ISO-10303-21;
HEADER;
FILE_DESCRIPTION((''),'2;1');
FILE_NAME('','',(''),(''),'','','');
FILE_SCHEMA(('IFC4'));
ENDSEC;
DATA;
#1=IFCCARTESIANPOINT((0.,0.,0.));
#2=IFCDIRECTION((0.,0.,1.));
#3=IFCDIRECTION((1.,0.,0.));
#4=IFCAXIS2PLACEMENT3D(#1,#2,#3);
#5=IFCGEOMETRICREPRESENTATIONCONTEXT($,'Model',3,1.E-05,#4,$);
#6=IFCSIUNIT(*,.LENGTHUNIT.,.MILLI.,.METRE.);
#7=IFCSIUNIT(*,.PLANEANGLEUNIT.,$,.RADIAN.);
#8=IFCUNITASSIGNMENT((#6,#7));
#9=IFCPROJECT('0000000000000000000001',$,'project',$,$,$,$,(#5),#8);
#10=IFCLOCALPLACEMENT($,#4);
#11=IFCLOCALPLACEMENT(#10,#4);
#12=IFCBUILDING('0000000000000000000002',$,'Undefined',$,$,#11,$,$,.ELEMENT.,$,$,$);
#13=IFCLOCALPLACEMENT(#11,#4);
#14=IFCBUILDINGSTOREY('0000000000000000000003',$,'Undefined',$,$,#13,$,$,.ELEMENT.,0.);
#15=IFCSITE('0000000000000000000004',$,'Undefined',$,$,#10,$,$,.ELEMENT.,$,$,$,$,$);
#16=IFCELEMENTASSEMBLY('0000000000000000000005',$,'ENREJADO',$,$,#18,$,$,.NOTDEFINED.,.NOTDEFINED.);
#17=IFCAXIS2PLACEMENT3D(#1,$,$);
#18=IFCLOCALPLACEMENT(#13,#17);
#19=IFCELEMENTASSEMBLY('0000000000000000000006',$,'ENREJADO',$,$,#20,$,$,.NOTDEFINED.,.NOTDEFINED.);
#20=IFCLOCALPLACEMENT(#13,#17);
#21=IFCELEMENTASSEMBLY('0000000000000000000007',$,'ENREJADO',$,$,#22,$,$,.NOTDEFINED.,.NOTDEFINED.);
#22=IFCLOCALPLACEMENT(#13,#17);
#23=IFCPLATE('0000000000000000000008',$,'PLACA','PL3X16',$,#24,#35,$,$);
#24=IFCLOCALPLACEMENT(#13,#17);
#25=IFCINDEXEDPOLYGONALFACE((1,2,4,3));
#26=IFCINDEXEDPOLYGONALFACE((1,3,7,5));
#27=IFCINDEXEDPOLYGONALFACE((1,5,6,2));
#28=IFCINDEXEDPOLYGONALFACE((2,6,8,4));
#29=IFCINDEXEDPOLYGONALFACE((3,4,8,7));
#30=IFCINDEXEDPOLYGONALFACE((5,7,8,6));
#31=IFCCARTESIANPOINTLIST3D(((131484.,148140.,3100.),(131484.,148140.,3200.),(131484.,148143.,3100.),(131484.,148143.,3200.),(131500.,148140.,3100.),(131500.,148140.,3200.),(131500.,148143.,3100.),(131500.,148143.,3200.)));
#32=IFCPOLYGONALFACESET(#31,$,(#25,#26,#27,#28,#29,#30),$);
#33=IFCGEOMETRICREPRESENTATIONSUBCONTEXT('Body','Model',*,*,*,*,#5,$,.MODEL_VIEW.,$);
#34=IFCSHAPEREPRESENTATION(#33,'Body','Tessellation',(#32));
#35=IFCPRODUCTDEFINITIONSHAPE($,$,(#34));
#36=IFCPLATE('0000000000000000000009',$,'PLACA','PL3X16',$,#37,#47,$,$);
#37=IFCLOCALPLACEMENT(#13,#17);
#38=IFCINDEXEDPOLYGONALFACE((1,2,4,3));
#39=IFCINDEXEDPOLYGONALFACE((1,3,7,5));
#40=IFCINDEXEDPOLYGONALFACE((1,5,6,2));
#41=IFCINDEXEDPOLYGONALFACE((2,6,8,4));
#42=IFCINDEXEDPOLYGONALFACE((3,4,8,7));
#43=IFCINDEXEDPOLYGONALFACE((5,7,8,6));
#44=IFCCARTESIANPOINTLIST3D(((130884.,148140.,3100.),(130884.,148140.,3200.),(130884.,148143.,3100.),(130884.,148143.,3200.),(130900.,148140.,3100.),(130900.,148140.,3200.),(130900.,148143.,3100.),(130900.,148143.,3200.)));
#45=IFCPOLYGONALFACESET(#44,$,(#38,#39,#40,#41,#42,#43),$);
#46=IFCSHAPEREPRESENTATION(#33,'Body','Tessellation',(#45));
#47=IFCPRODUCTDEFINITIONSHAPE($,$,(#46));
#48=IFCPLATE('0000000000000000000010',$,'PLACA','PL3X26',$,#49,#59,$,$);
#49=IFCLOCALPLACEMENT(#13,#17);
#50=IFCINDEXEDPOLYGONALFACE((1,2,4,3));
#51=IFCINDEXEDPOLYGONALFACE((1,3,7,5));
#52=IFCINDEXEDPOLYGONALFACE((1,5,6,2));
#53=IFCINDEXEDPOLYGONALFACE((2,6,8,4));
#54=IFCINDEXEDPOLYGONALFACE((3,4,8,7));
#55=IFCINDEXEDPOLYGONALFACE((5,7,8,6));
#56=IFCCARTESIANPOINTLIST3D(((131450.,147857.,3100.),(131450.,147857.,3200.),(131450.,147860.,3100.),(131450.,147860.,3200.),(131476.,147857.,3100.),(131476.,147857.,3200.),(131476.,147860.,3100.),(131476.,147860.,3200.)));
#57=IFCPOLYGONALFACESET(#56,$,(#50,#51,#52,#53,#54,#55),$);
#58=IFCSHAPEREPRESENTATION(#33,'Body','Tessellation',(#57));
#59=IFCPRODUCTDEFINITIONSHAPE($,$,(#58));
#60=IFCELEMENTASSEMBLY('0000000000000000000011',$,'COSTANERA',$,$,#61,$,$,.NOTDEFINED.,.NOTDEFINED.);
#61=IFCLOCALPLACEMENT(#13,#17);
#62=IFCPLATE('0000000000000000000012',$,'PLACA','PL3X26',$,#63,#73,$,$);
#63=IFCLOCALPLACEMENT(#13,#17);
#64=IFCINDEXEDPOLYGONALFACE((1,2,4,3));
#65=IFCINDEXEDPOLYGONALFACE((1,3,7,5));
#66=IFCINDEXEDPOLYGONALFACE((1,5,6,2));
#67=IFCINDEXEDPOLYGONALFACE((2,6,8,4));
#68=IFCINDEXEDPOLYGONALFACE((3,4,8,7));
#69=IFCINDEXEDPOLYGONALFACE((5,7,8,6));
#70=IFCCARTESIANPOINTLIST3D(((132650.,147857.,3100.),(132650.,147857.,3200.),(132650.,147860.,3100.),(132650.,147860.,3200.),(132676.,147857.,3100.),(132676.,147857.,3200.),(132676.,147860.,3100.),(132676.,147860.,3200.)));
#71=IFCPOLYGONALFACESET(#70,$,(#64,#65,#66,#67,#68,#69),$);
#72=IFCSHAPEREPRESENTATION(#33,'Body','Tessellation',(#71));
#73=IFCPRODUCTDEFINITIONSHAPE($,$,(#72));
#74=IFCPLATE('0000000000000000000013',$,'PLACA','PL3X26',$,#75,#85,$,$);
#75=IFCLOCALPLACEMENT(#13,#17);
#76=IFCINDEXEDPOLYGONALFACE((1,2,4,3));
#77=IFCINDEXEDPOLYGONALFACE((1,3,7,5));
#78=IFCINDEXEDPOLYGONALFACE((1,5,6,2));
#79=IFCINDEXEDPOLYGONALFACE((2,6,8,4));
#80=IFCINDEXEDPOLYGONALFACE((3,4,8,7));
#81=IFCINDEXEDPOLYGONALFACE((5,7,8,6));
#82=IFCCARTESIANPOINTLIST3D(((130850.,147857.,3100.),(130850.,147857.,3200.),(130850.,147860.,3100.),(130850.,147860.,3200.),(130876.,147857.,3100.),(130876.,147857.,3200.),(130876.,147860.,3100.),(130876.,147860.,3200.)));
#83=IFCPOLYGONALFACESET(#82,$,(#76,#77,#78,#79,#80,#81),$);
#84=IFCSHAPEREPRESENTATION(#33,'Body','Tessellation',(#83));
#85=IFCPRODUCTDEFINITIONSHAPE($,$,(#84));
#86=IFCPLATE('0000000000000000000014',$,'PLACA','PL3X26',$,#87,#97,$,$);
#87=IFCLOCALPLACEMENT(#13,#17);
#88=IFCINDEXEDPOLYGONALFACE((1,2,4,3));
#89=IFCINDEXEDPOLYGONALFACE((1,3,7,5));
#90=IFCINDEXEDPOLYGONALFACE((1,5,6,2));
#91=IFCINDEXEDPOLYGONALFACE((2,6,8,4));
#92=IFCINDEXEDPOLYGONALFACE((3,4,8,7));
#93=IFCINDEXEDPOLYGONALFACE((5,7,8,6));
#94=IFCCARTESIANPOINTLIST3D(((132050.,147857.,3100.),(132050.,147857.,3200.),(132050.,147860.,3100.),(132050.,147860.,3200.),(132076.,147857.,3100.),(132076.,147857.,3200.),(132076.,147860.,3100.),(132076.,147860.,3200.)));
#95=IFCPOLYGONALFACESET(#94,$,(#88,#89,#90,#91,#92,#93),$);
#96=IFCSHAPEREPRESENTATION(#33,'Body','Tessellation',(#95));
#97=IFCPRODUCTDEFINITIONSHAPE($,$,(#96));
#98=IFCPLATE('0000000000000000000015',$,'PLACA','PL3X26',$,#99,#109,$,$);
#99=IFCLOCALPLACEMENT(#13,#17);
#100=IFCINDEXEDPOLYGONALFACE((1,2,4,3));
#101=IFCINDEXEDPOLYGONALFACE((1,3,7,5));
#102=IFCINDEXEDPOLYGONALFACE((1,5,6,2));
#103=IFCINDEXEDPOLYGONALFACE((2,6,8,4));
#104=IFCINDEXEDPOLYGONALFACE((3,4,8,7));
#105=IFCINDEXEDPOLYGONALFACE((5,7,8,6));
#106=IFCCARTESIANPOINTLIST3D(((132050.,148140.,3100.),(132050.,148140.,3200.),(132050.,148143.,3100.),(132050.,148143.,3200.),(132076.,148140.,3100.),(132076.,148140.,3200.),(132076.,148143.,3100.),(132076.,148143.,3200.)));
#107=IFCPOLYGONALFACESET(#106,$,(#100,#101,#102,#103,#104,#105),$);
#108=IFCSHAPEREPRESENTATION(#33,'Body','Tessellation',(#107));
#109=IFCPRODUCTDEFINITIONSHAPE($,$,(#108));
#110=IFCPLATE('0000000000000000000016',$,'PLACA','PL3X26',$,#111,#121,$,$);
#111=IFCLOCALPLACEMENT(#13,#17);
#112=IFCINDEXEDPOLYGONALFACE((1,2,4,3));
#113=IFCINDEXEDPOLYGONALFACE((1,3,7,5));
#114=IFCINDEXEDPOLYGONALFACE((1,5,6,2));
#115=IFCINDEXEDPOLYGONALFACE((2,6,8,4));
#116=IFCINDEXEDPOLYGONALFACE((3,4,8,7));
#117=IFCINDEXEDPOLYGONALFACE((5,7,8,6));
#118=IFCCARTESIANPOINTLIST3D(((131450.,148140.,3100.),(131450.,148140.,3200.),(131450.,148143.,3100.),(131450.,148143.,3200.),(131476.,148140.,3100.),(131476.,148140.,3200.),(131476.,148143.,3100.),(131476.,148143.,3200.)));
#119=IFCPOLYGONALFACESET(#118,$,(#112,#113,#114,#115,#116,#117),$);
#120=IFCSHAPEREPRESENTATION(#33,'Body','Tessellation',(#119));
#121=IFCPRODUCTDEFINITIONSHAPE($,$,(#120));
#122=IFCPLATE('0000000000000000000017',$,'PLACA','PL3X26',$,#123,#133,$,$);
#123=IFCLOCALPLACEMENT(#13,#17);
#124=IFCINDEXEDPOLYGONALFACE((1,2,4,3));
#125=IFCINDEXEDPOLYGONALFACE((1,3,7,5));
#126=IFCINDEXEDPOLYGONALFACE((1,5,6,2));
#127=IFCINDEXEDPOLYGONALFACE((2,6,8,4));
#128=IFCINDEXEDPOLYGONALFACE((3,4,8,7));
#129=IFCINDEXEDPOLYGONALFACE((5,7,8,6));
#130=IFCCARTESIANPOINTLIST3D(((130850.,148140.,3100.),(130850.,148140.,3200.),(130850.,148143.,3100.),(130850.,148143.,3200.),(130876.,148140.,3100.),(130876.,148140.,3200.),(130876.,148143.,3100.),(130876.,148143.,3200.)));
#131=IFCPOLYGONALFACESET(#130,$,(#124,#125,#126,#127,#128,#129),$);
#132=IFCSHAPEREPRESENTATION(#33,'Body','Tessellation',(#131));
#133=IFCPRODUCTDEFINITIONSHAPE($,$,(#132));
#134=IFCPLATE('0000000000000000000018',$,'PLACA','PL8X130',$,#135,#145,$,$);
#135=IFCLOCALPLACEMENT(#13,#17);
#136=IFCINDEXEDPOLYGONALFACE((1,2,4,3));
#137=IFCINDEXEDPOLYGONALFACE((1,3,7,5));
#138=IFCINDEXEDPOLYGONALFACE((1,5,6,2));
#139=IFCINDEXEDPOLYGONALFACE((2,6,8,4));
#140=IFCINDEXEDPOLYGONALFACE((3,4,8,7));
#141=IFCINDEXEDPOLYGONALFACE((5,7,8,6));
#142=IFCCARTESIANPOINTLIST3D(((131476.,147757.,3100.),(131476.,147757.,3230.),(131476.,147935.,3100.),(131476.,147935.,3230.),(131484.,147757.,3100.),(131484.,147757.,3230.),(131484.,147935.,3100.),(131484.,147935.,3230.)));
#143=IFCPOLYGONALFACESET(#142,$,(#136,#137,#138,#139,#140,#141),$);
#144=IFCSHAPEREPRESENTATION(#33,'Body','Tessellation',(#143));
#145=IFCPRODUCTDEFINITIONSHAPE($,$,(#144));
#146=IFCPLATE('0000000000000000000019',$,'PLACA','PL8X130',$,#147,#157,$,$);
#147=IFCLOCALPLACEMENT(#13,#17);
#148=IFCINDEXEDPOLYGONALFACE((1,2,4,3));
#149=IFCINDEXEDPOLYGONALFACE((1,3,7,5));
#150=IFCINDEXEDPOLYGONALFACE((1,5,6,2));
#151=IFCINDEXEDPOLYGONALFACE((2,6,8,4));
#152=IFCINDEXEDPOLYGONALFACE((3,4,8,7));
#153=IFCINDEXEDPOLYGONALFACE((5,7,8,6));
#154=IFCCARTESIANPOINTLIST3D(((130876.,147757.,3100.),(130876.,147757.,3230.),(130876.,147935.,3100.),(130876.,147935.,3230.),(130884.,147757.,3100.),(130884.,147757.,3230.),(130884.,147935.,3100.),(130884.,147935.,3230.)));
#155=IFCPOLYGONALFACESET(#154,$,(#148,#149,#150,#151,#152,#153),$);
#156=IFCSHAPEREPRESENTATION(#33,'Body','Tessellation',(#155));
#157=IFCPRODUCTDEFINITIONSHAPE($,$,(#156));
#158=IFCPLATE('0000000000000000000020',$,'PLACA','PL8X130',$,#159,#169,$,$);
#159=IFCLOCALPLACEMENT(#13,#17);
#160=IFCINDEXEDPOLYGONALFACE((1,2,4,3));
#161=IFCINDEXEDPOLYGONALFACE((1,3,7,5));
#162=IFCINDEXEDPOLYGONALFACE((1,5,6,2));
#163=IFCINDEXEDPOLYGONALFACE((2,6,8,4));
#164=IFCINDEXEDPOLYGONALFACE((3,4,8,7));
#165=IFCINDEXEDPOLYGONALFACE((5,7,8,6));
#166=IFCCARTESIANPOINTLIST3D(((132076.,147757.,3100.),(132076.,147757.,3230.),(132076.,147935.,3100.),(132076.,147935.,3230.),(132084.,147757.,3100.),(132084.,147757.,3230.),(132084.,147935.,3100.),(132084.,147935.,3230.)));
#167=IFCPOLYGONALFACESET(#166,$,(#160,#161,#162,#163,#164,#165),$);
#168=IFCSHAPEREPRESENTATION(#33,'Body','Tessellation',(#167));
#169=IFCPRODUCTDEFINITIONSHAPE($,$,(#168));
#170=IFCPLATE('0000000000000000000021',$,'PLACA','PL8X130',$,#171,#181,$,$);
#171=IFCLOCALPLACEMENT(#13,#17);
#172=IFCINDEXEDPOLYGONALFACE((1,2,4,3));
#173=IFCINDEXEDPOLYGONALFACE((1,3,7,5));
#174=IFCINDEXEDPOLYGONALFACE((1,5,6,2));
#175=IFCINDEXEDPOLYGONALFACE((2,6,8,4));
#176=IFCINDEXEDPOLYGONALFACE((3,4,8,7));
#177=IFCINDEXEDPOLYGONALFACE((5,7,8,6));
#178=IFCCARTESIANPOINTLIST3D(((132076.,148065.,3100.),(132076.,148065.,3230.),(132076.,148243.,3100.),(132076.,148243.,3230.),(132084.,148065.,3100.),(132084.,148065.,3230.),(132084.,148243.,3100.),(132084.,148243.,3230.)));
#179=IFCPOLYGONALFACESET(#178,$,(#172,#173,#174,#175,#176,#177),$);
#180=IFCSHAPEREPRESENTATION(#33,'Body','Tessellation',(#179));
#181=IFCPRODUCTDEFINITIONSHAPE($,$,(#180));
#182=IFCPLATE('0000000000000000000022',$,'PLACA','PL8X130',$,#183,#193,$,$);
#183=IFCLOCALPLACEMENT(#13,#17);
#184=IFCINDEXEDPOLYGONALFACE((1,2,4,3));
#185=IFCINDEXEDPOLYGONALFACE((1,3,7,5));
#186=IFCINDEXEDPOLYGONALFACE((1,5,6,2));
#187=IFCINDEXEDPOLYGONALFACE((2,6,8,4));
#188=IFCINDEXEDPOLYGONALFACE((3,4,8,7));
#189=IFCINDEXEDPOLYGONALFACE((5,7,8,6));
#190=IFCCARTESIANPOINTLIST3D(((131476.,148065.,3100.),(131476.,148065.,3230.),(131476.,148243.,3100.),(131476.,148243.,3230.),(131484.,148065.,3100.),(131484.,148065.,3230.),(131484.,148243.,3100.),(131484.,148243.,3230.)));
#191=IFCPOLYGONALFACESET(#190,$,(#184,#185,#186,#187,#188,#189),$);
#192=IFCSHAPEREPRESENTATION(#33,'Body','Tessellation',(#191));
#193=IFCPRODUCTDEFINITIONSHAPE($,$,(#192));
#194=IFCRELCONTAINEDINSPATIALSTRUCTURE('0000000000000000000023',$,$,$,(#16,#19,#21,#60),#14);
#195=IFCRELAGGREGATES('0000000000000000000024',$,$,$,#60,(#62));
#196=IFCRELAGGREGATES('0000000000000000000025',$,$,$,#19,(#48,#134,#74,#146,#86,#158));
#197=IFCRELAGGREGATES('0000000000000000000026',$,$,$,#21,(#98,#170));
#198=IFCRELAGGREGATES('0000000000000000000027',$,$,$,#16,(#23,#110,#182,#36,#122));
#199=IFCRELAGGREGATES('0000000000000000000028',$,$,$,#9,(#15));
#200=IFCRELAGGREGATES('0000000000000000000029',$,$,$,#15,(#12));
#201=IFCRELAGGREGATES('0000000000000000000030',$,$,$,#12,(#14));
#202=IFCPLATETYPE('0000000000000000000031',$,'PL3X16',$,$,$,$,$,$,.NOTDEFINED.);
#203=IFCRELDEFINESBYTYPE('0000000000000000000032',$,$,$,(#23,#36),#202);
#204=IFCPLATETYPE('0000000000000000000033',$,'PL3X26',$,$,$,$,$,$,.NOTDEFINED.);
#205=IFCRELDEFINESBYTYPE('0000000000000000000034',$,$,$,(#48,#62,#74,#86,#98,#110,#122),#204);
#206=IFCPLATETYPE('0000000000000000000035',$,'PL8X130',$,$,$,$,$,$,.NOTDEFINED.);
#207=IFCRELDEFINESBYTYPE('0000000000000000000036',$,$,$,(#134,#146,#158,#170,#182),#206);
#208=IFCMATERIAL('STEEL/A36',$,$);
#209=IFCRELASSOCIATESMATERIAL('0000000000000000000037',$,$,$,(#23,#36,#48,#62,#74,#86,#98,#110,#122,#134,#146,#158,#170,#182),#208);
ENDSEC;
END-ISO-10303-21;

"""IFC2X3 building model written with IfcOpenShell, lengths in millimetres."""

from ifc_helpers import new_model, si_unit, frame, origin_with_axes, place, context, subcontext, project, spatial, polyline, outline, extrude, material, type_object, element, aggregate, save


model = new_model("IFC2X3")

# Units and contexts
model_context = context("Model", 3, precision=1e-05, world=origin_with_axes())
body_context = subcontext(model_context, "Body", "Model", "MODEL_VIEW")
ifc_project = project(units=[si_unit("LENGTHUNIT", "METRE", prefix="MILLI"), si_unit("PLANEANGLEUNIT", "RADIAN")], contexts=[model_context])

# Site, building, storey
site_placement = place(None, origin_with_axes())
site = spatial("IfcSite", under=ifc_project, at=site_placement, Name="Undefined", CompositionType="ELEMENT")
building_placement = place(site_placement, origin_with_axes())
building = spatial("IfcBuilding", under=site, at=building_placement, Name="Undefined", CompositionType="ELEMENT")
storey_placement = place(building_placement, origin_with_axes())
storey = spatial("IfcBuildingStorey", under=building, at=storey_placement, Name="Undefined", CompositionType="ELEMENT", Elevation=0.0)

# Shared definitions
ifc_material_1 = material(Name="STEEL/A36")

# Element assembly
assembly_1_placement = place(storey_placement, origin_with_axes())
assembly_1 = element("IfcElementAssembly", 1, at=assembly_1_placement, inside=storey, Name="ENREJADO", AssemblyPlace="NOTDEFINED", PredefinedType="NOTDEFINED")

# Element assembly
assembly_2_placement = place(storey_placement, origin_with_axes())
assembly_2 = element("IfcElementAssembly", 2, at=assembly_2_placement, inside=storey, Name="ENREJADO", AssemblyPlace="NOTDEFINED", PredefinedType="NOTDEFINED")

# Element assembly
assembly_3_placement = place(storey_placement, origin_with_axes())
assembly_3 = element("IfcElementAssembly", 3, at=assembly_3_placement, inside=storey, Name="ENREJADO", AssemblyPlace="NOTDEFINED", PredefinedType="NOTDEFINED")

# Plates
plate_type_1 = type_object("IfcPlateType", Name="PL3X16", PredefinedType="NOTDEFINED")
plate_1_placement = place(assembly_1_placement, frame((131500.0, 148141.5, 3100.0), z_axis=(0.000001, 1.0, 0.0), x_axis=(-1.0, 0.000001, 0.0)))
plate_1 = element("IfcPlate", 4, at=plate_1_placement, type_object=plate_type_1, material=ifc_material_1, Name="PLACA", Description="PL3X16", context=body_context, shape_type="SweptSolid", body=[
    extrude(outline(polyline([(0.0, 0.0), (16.0, 0.0), (16.0, 100.0), (0.0, 100.0), (0.0, 0.0)])), frame((0.0, 0.0, -1.5), z_axis=(0.0, 0.0, 1.0), x_axis=(1.0, 0.0, 0.0)), (0.0, 0.0, 1.0), 3.0),
])
plate_2_placement = place(assembly_1_placement, frame((130900.0, 148141.5, 3100.0), z_axis=(0.000001, 1.0, 0.0), x_axis=(-1.0, 0.000001, 0.0)))
plate_2 = element("IfcPlate", 5, at=plate_2_placement, type_object=plate_type_1, material=ifc_material_1, Name="PLACA", Description="PL3X16", context=body_context, shape_type="SweptSolid", body=[
    extrude(outline(polyline([(0.0, 0.0), (16.0, 0.0), (16.0, 100.0), (0.0, 100.0), (0.0, 0.0)])), frame((0.0, 0.0, -1.5), z_axis=(0.0, 0.0, 1.0), x_axis=(1.0, 0.0, 0.0)), (0.0, 0.0, 1.0), 3.0),
])
plate_type_2 = type_object("IfcPlateType", Name="PL3X26", PredefinedType="NOTDEFINED")
plate_3_placement = place(assembly_2_placement, frame((131476.0, 147858.5, 3200.0), z_axis=(0.000001, -1.0, 0.0), x_axis=(-1.0, -0.000001, 0.0)))
plate_3 = element("IfcPlate", 6, at=plate_3_placement, type_object=plate_type_2, material=ifc_material_1, Name="PLACA", Description="PL3X26", context=body_context, shape_type="SweptSolid", body=[
    extrude(outline(polyline([(0.0, 0.0), (26.0, 0.0), (26.0, 100.0), (0.0, 100.0), (0.0, 0.0)])), frame((0.0, 0.0, -1.5), z_axis=(0.0, 0.0, 1.0), x_axis=(1.0, 0.0, 0.0)), (0.0, 0.0, 1.0), 3.0),
])

# Element assembly, plate
assembly_4_placement = place(storey_placement, origin_with_axes())
assembly_4 = element("IfcElementAssembly", 7, at=assembly_4_placement, inside=storey, Name="COSTANERA", AssemblyPlace="NOTDEFINED", PredefinedType="NOTDEFINED")
plate_4_placement = place(assembly_4_placement, frame((132676.0, 147858.5, 3200.0), z_axis=(0.000001, -1.0, 0.0), x_axis=(-1.0, -0.000001, 0.0)))
plate_4 = element("IfcPlate", 8, at=plate_4_placement, type_object=plate_type_2, material=ifc_material_1, Name="PLACA", Description="PL3X26", context=body_context, shape_type="SweptSolid", body=[
    extrude(outline(polyline([(0.0, 0.0), (26.0, 0.0), (26.0, 100.0), (0.0, 100.0), (0.0, 0.0)])), frame((0.0, 0.0, -1.5), z_axis=(0.0, 0.0, 1.0), x_axis=(1.0, 0.0, 0.0)), (0.0, 0.0, 1.0), 3.0),
])
aggregate(assembly_4, [plate_4])

# Plates
plate_5_placement = place(assembly_2_placement, frame((130876.0, 147858.5, 3200.0), z_axis=(0.000001, -1.0, 0.0), x_axis=(-1.0, -0.000001, 0.0)))
plate_5 = element("IfcPlate", 9, at=plate_5_placement, type_object=plate_type_2, material=ifc_material_1, Name="PLACA", Description="PL3X26", context=body_context, shape_type="SweptSolid", body=[
    extrude(outline(polyline([(0.0, 0.0), (26.0, 0.0), (26.0, 100.0), (0.0, 100.0), (0.0, 0.0)])), frame((0.0, 0.0, -1.5), z_axis=(0.0, 0.0, 1.0), x_axis=(1.0, 0.0, 0.0)), (0.0, 0.0, 1.0), 3.0),
])
plate_6_placement = place(assembly_2_placement, frame((132076.0, 147858.5, 3200.0), z_axis=(0.000001, -1.0, 0.0), x_axis=(-1.0, -0.000001, 0.0)))
plate_6 = element("IfcPlate", 10, at=plate_6_placement, type_object=plate_type_2, material=ifc_material_1, Name="PLACA", Description="PL3X26", context=body_context, shape_type="SweptSolid", body=[
    extrude(outline(polyline([(0.0, 0.0), (26.0, 0.0), (26.0, 100.0), (0.0, 100.0), (0.0, 0.0)])), frame((0.0, 0.0, -1.5), z_axis=(0.0, 0.0, 1.0), x_axis=(1.0, 0.0, 0.0)), (0.0, 0.0, 1.0), 3.0),
])
plate_7_placement = place(assembly_3_placement, frame((132076.0, 148141.5, 3100.0), z_axis=(0.000001, 1.0, 0.0), x_axis=(-1.0, 0.000001, 0.0)))
plate_7 = element("IfcPlate", 11, at=plate_7_placement, type_object=plate_type_2, material=ifc_material_1, Name="PLACA", Description="PL3X26", context=body_context, shape_type="SweptSolid", body=[
    extrude(outline(polyline([(0.0, 0.0), (26.0, 0.0), (26.0, 100.0), (0.0, 100.0), (0.0, 0.0)])), frame((0.0, 0.0, -1.5), z_axis=(0.0, 0.0, 1.0), x_axis=(1.0, 0.0, 0.0)), (0.0, 0.0, 1.0), 3.0),
])
plate_8_placement = place(assembly_1_placement, frame((131476.0, 148141.5, 3100.0), z_axis=(0.000001, 1.0, 0.0), x_axis=(-1.0, 0.000001, 0.0)))
plate_8 = element("IfcPlate", 12, at=plate_8_placement, type_object=plate_type_2, material=ifc_material_1, Name="PLACA", Description="PL3X26", context=body_context, shape_type="SweptSolid", body=[
    extrude(outline(polyline([(0.0, 0.0), (26.0, 0.0), (26.0, 100.0), (0.0, 100.0), (0.0, 0.0)])), frame((0.0, 0.0, -1.5), z_axis=(0.0, 0.0, 1.0), x_axis=(1.0, 0.0, 0.0)), (0.0, 0.0, 1.0), 3.0),
])
plate_9_placement = place(assembly_1_placement, frame((130876.0, 148141.5, 3100.0), z_axis=(0.000001, 1.0, 0.0), x_axis=(-1.0, 0.000001, 0.0)))
plate_9 = element("IfcPlate", 13, at=plate_9_placement, type_object=plate_type_2, material=ifc_material_1, Name="PLACA", Description="PL3X26", context=body_context, shape_type="SweptSolid", body=[
    extrude(outline(polyline([(0.0, 0.0), (26.0, 0.0), (26.0, 100.0), (0.0, 100.0), (0.0, 0.0)])), frame((0.0, 0.0, -1.5), z_axis=(0.0, 0.0, 1.0), x_axis=(1.0, 0.0, 0.0)), (0.0, 0.0, 1.0), 3.0),
])
plate_type_3 = type_object("IfcPlateType", Name="PL8X130", PredefinedType="NOTDEFINED")
plate_10_placement = place(assembly_2_placement, frame((131480.0, 147935.0, 3165.0), z_axis=(-1.0, -0.000001, 0.0), x_axis=(0.000001, -1.0, 0.0)))
plate_10 = element("IfcPlate", 14, at=plate_10_placement, type_object=plate_type_3, material=ifc_material_1, Name="PLACA", Description="PL8X130", context=body_context, shape_type="SweptSolid", body=[
    extrude(outline(polyline([(0.0, -65.0), (0.0, 65.0), (178.0, 65.0), (178.0, -65.0), (0.0, -65.0)])), frame((0.0, 0.0, -4.0), z_axis=(0.0, 0.0, 1.0), x_axis=(1.0, 0.0, 0.0)), (0.0, 0.0, 1.0), 8.0),
])
plate_11_placement = place(assembly_2_placement, frame((130880.0, 147935.0, 3165.0), z_axis=(-1.0, -0.000001, 0.0), x_axis=(0.000001, -1.0, 0.0)))
plate_11 = element("IfcPlate", 15, at=plate_11_placement, type_object=plate_type_3, material=ifc_material_1, Name="PLACA", Description="PL8X130", context=body_context, shape_type="SweptSolid", body=[
    extrude(outline(polyline([(0.0, -65.0), (0.0, 65.0), (178.0, 65.0), (178.0, -65.0), (0.0, -65.0)])), frame((0.0, 0.0, -4.0), z_axis=(0.0, 0.0, 1.0), x_axis=(1.0, 0.0, 0.0)), (0.0, 0.0, 1.0), 8.0),
])
plate_12_placement = place(assembly_2_placement, frame((132080.0, 147935.0, 3165.0), z_axis=(-1.0, -0.000001, 0.0), x_axis=(0.000001, -1.0, 0.0)))
plate_12 = element("IfcPlate", 16, at=plate_12_placement, type_object=plate_type_3, material=ifc_material_1, Name="PLACA", Description="PL8X130", context=body_context, shape_type="SweptSolid", body=[
    extrude(outline(polyline([(0.0, -65.0), (0.0, 65.0), (178.0, 65.0), (178.0, -65.0), (0.0, -65.0)])), frame((0.0, 0.0, -4.0), z_axis=(0.0, 0.0, 1.0), x_axis=(1.0, 0.0, 0.0)), (0.0, 0.0, 1.0), 8.0),
])
aggregate(assembly_2, [plate_3, plate_10, plate_5, plate_11, plate_6, plate_12])
plate_13_placement = place(assembly_3_placement, frame((132080.0, 148065.0, 3165.0), z_axis=(-1.0, 0.000001, 0.0), x_axis=(0.000001, 1.0, 0.0)))
plate_13 = element("IfcPlate", 17, at=plate_13_placement, type_object=plate_type_3, material=ifc_material_1, Name="PLACA", Description="PL8X130", context=body_context, shape_type="SweptSolid", body=[
    extrude(outline(polyline([(0.0, -65.0), (0.0, 65.0), (178.0, 65.0), (178.0, -65.0), (0.0, -65.0)])), frame((0.0, 0.0, -4.0), z_axis=(0.0, 0.0, 1.0), x_axis=(1.0, 0.0, 0.0)), (0.0, 0.0, 1.0), 8.0),
])
aggregate(assembly_3, [plate_7, plate_13])
plate_14_placement = place(assembly_1_placement, frame((131480.0, 148065.0, 3165.0), z_axis=(-1.0, 0.000001, 0.0), x_axis=(0.000001, 1.0, 0.0)))
plate_14 = element("IfcPlate", 18, at=plate_14_placement, type_object=plate_type_3, material=ifc_material_1, Name="PLACA", Description="PL8X130", context=body_context, shape_type="SweptSolid", body=[
    extrude(outline(polyline([(0.0, -65.0), (0.0, 65.0), (178.0, 65.0), (178.0, -65.0), (0.0, -65.0)])), frame((0.0, 0.0, -4.0), z_axis=(0.0, 0.0, 1.0), x_axis=(1.0, 0.0, 0.0)), (0.0, 0.0, 1.0), 8.0),
])
aggregate(assembly_1, [plate_1, plate_8, plate_14, plate_2, plate_9])

save(model, "model.ifc")
